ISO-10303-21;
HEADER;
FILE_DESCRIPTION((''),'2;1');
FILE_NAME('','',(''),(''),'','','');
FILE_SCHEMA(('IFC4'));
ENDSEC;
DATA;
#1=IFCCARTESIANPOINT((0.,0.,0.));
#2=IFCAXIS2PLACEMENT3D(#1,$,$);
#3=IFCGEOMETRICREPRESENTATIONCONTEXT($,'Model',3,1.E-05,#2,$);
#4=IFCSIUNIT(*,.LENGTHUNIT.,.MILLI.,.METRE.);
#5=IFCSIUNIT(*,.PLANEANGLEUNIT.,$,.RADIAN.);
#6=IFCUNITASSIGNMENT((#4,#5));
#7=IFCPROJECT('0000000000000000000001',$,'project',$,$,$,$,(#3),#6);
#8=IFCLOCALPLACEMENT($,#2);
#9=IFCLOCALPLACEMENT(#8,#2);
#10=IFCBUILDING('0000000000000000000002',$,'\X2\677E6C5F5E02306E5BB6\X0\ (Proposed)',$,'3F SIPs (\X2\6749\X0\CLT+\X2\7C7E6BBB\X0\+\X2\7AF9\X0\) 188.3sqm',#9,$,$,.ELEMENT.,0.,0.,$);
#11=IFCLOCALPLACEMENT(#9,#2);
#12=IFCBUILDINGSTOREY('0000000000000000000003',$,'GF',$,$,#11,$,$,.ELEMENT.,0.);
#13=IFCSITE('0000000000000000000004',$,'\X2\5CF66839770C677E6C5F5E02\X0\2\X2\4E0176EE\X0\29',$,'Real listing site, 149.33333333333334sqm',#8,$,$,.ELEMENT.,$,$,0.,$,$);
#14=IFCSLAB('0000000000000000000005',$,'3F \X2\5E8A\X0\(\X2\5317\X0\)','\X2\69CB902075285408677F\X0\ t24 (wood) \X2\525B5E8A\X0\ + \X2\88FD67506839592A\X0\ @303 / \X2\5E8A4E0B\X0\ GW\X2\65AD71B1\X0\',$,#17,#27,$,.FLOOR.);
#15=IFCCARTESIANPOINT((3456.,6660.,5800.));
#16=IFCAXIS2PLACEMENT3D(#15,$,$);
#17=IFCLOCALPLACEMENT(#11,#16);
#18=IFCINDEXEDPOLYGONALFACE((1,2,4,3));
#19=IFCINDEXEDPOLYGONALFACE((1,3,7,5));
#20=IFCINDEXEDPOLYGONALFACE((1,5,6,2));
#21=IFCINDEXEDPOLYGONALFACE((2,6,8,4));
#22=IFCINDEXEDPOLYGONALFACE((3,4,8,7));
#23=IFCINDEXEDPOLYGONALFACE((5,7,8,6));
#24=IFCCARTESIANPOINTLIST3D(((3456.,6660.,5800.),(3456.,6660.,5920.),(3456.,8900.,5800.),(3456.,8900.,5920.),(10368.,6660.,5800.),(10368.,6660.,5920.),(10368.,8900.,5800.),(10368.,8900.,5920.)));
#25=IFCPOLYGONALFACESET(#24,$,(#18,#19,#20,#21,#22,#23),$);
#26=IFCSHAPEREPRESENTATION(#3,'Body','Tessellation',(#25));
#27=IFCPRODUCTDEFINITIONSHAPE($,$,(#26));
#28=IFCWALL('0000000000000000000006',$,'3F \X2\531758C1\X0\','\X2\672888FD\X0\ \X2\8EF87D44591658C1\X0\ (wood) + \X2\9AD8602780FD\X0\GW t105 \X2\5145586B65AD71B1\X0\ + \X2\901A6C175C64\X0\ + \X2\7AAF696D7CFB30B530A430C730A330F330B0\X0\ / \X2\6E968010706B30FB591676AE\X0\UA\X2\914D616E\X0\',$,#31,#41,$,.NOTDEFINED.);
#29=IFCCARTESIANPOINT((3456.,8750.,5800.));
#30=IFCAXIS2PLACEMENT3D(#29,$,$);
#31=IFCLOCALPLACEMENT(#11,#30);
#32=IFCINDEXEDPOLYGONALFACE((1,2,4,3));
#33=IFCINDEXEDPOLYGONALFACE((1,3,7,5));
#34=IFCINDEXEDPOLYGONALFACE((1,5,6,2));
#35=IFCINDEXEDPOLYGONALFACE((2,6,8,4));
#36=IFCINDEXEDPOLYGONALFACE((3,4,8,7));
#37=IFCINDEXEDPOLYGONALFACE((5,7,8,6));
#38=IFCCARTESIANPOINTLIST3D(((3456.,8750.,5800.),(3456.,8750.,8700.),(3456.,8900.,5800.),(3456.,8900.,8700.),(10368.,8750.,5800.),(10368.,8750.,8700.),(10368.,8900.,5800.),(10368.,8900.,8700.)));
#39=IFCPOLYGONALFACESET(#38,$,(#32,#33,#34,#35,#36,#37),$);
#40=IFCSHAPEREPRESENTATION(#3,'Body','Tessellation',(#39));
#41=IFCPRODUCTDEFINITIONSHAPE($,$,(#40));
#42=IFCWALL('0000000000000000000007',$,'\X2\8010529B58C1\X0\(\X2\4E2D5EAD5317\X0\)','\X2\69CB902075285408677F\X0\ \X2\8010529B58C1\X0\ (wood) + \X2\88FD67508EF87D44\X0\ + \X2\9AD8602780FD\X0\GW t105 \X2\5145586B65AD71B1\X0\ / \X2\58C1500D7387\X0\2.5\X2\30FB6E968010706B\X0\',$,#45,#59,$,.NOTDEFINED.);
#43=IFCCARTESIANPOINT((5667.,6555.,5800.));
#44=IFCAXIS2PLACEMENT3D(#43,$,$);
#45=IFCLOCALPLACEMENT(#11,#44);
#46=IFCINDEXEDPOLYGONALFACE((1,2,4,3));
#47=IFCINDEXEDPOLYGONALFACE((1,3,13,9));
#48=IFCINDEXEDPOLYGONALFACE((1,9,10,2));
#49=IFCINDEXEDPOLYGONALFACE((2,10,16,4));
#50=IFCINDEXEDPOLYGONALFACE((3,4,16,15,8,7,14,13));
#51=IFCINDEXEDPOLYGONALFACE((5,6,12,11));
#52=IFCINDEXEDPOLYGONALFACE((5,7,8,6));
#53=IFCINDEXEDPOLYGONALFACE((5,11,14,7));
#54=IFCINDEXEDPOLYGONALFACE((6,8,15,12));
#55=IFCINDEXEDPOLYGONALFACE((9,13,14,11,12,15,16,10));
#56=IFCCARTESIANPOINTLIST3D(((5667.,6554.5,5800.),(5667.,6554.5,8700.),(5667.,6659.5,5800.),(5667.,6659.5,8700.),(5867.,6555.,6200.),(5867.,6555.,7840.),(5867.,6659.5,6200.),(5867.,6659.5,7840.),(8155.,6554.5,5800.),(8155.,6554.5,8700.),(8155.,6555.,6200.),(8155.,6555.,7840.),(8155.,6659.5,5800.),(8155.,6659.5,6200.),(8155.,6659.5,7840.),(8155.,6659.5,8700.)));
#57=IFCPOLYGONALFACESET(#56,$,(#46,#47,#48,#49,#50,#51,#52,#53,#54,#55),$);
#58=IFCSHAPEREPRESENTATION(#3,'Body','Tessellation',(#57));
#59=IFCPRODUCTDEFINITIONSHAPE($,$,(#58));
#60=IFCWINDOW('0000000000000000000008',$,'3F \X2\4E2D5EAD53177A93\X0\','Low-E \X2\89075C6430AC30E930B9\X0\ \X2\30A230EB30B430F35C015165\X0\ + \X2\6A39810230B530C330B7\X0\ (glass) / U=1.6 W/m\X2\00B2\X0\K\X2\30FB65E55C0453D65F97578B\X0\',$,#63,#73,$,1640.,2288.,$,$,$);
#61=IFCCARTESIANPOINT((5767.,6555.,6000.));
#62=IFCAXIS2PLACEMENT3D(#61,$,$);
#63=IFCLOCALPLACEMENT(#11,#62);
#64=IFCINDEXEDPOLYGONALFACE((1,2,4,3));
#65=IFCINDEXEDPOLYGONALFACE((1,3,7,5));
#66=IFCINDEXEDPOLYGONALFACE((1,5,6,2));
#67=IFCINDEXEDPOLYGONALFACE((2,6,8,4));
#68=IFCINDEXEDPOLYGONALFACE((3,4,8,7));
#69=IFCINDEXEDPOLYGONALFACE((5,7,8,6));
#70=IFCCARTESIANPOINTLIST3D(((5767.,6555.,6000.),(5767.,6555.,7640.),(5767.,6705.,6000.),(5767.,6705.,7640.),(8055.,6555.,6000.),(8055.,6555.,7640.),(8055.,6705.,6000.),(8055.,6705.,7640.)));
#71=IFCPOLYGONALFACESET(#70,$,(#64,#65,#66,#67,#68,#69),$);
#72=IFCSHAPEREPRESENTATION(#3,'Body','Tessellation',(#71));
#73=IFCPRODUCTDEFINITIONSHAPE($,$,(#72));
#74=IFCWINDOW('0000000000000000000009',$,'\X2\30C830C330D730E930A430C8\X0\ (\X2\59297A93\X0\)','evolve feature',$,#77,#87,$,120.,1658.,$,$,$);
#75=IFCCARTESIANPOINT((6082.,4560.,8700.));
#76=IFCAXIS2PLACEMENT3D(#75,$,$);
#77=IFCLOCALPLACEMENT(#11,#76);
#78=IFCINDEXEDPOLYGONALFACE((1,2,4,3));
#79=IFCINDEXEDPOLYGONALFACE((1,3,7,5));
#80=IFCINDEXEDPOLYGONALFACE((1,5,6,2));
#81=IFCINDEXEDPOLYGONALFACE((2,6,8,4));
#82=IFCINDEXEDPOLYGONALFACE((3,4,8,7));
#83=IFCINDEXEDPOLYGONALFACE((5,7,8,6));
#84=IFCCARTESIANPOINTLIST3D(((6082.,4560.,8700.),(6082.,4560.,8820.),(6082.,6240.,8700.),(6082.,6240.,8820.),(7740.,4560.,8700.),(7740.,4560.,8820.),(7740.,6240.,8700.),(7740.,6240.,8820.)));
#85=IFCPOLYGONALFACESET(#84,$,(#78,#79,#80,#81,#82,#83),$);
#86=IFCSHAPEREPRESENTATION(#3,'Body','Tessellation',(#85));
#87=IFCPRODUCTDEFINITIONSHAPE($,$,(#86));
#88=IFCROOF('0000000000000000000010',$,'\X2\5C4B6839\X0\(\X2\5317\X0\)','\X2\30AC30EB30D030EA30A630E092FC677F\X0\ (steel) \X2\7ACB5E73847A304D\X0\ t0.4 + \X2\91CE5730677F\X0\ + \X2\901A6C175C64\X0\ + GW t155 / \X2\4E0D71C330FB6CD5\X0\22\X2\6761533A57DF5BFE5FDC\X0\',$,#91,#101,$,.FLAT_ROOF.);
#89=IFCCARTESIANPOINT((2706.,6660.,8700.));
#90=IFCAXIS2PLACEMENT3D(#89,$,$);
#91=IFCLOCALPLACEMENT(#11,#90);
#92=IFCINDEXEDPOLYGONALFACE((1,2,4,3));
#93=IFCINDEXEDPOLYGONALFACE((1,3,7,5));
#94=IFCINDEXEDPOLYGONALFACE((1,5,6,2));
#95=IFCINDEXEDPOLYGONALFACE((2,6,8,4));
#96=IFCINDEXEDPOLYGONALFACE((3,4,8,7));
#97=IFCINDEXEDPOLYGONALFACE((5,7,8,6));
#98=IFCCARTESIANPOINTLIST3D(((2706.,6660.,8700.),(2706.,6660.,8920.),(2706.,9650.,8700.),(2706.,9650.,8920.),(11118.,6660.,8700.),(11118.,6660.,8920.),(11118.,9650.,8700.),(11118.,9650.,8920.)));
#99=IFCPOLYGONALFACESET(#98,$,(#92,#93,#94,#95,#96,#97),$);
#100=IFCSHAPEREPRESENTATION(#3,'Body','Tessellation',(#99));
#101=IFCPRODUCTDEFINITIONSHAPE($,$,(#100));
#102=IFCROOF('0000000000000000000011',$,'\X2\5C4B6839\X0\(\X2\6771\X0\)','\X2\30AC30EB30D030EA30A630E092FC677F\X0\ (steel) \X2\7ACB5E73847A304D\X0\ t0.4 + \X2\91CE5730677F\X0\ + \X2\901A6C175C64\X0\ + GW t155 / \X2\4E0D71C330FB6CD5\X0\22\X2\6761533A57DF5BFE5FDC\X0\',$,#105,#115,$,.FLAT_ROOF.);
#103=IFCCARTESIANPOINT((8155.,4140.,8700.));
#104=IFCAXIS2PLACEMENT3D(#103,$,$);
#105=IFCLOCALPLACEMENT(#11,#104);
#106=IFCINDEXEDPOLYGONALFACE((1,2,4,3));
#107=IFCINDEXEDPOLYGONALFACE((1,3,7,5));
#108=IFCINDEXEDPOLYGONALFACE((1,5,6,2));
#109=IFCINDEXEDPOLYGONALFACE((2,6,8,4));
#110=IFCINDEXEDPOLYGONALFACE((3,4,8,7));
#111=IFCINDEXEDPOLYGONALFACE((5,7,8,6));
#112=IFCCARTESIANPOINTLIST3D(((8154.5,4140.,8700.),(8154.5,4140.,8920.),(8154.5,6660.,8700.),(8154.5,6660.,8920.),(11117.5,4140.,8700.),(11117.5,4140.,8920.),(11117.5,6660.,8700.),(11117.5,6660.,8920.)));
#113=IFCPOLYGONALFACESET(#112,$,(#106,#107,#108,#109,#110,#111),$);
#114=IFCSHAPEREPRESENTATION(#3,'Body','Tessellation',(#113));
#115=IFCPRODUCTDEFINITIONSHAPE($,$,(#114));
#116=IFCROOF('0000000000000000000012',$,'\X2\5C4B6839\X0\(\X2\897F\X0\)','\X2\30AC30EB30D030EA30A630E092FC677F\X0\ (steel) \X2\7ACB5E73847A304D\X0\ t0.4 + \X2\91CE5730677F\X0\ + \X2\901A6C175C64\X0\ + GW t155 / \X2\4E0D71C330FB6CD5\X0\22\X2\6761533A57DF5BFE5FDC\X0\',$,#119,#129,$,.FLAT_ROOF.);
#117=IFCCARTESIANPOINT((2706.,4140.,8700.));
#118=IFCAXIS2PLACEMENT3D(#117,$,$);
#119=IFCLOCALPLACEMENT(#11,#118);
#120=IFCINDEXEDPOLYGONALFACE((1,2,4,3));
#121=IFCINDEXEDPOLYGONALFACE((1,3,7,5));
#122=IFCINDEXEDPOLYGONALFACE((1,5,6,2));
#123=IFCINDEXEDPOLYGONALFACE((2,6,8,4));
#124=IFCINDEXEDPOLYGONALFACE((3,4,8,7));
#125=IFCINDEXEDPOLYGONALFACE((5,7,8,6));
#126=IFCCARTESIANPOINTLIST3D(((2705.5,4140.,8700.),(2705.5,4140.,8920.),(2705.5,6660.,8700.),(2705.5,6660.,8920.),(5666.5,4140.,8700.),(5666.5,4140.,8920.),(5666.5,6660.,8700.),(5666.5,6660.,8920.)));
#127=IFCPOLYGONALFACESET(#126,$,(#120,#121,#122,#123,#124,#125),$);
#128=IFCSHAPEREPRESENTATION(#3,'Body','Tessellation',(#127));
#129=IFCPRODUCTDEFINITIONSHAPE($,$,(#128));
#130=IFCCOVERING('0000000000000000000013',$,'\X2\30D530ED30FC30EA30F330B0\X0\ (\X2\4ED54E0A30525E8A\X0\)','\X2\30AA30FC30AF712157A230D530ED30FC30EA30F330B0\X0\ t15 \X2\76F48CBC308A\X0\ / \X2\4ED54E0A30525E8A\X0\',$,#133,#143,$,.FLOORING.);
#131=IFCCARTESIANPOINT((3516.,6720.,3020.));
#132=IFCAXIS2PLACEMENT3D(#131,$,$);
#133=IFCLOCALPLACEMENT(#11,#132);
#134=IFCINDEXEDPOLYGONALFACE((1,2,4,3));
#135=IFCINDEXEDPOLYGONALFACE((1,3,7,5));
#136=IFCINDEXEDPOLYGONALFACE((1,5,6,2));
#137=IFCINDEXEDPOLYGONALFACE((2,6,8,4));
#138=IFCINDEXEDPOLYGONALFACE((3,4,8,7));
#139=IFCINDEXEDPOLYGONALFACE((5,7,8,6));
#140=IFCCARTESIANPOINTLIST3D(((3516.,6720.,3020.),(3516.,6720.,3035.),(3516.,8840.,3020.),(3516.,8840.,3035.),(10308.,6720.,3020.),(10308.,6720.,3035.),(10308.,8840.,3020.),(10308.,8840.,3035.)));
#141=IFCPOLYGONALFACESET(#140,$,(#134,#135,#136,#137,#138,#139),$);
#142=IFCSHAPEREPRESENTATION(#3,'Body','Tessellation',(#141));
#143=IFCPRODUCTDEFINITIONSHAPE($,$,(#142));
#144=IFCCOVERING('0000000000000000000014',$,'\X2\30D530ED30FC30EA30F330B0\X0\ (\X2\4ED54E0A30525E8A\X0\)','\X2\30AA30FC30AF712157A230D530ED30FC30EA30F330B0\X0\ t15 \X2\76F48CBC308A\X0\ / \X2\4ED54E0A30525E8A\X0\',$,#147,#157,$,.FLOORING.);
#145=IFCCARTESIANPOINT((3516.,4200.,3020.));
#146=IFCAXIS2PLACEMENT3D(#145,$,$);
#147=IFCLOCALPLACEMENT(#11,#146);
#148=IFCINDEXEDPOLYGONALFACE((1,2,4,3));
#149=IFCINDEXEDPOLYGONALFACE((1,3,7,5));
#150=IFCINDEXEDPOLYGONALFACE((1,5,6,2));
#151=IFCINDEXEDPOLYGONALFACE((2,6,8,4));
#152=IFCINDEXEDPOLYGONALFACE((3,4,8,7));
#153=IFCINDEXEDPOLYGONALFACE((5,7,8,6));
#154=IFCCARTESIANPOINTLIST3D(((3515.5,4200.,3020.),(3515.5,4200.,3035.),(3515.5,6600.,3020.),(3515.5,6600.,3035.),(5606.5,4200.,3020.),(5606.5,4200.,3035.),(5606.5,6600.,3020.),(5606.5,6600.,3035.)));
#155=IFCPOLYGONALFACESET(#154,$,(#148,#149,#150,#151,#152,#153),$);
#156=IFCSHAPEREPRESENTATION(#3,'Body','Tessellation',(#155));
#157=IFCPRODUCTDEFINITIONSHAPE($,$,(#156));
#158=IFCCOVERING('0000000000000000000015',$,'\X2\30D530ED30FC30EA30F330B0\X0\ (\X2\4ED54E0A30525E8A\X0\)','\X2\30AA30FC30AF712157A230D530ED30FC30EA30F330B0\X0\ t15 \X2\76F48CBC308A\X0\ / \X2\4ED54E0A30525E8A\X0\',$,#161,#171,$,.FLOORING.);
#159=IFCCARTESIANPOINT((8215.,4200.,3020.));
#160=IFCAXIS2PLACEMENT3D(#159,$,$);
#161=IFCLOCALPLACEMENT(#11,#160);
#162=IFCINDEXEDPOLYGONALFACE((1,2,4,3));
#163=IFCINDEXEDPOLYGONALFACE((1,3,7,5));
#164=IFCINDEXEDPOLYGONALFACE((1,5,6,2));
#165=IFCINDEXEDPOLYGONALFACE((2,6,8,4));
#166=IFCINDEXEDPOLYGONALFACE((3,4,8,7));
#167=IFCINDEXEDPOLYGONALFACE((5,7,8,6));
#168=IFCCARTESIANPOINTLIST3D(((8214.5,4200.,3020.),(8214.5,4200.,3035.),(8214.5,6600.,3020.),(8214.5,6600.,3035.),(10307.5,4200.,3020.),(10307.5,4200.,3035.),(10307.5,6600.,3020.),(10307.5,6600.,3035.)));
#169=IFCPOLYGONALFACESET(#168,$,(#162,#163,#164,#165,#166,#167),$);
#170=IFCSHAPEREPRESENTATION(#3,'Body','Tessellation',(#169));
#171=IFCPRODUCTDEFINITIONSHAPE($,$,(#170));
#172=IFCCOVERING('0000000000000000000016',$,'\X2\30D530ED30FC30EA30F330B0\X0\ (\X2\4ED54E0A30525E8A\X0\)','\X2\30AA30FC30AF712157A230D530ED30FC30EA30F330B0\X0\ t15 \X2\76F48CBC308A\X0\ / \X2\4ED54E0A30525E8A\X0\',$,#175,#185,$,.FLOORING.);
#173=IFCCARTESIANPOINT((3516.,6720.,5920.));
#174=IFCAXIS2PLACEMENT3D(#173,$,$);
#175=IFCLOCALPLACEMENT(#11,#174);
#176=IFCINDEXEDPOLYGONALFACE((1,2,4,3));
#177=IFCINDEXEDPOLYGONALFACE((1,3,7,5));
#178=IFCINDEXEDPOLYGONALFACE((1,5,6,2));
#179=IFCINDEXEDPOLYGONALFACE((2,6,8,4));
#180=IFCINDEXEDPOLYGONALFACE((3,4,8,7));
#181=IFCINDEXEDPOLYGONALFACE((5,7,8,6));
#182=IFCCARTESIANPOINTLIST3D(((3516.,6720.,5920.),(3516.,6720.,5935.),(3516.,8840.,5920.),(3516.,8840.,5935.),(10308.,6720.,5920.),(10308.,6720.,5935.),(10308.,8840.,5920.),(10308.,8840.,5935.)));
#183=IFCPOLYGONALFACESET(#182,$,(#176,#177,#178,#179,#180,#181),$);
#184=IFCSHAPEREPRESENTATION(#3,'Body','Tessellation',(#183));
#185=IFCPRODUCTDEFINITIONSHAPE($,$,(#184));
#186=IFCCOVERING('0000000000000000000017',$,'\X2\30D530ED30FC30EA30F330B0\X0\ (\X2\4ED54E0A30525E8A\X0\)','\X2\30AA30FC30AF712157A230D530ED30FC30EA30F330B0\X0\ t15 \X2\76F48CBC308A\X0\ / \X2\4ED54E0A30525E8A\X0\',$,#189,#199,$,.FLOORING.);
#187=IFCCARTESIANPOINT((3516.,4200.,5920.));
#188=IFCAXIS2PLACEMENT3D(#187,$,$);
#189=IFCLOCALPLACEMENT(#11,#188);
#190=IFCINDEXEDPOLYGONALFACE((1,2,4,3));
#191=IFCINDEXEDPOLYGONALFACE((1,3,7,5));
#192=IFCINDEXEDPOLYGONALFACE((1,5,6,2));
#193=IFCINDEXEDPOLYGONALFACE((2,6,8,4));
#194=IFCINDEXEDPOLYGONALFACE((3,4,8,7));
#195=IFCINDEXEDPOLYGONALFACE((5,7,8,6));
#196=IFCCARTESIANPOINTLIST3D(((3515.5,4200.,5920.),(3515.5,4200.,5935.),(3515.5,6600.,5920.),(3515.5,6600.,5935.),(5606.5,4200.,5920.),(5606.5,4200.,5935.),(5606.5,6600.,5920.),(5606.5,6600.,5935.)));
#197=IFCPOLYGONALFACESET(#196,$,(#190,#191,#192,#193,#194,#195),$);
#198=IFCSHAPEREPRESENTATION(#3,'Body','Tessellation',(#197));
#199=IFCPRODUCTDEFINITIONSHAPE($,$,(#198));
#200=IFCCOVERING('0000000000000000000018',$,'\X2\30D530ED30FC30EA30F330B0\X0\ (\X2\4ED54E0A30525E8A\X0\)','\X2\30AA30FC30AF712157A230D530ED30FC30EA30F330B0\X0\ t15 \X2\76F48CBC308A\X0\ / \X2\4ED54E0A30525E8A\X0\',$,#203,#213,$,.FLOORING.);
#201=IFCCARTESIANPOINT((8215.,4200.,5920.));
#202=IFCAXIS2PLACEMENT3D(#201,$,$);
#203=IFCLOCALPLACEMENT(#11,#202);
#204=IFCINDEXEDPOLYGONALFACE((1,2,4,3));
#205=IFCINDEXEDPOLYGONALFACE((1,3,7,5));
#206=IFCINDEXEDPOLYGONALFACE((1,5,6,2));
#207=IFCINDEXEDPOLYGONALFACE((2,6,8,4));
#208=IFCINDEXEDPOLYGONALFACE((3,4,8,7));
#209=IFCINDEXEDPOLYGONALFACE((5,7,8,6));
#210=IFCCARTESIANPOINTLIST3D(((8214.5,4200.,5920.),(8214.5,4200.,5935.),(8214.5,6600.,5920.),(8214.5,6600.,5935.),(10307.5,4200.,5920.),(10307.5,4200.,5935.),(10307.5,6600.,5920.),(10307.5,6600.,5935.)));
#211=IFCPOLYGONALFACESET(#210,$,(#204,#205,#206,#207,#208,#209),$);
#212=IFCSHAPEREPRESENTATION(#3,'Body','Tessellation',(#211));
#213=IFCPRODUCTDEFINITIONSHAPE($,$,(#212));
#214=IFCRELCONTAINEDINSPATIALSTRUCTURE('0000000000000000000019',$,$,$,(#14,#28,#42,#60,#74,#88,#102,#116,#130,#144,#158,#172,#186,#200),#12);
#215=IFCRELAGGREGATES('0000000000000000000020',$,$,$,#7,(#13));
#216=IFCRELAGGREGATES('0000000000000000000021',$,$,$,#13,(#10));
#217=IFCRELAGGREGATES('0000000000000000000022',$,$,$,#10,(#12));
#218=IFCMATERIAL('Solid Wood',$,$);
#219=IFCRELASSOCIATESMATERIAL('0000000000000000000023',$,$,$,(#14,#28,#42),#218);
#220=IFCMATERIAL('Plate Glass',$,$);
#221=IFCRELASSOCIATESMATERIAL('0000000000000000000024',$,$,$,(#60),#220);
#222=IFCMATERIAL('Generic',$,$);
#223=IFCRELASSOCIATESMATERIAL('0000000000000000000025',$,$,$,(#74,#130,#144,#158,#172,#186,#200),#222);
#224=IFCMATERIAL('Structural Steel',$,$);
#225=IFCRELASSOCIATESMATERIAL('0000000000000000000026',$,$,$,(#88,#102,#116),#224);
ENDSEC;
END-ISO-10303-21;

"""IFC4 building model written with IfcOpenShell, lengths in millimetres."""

from ifc_helpers import new_model, si_unit, frame, frame_2d, origin, place, context, project, spatial, rectangle, extrude, material, element, fill, save


model = new_model("IFC4")

# Units and contexts
model_context = context("Model", 3, precision=1e-05, world=origin())
ifc_project = project(units=[si_unit("LENGTHUNIT", "METRE", prefix="MILLI"), si_unit("PLANEANGLEUNIT", "RADIAN")], contexts=[model_context])

# Site, building, storey
site_placement = place(None, origin())
site = spatial("IfcSite", under=ifc_project, at=site_placement, Name="島根県松江市2丁目29", ObjectType="Real listing site, 149.33333333333334sqm", CompositionType="ELEMENT", RefElevation=0.0)
building_placement = place(site_placement, origin())
building = spatial("IfcBuilding", under=site, at=building_placement, Name="松江市の家 (Proposed)", ObjectType="3F SIPs (杉CLT+籾殻+竹) 188.3sqm", CompositionType="ELEMENT", ElevationOfRefHeight=0.0, ElevationOfTerrain=0.0)
storey_placement = place(building_placement, origin())
storey = spatial("IfcBuildingStorey", under=building, at=storey_placement, Name="GF", CompositionType="ELEMENT", Elevation=0.0)

# Slab
ifc_material_1 = material(Name="Solid Wood")
slab_placement = place(storey_placement, frame((3456.0, 6660.0, 5800.0)))
element("IfcSlab", 1, at=slab_placement, inside=storey, material=ifc_material_1, Name="3F 床(北)", Description="構造用合板 t24 (wood) 剛床 + 製材根太 @303 / 床下 GW断熱", PredefinedType="FLOOR", context=model_context, shape_type="SweptSolid", body=[
    extrude(rectangle(XDim=6912.0, YDim=2240.0, at=frame_2d((3456.0, 1120.0))), frame((3456.0, 6660.0, 5800.0)), (0.0, 0.0, 1.0), 120.0),
])

# Wall
wall_1_placement = place(storey_placement, frame((3456.0, 8750.0, 5800.0)))
element("IfcWall", 2, at=wall_1_placement, inside=storey, material=ifc_material_1, Name="3F 北壁", Description="木製 軸組外壁 (wood) + 高性能GW t105 充填断熱 + 通気層 + 窯業系サイディング / 準耐火・外皮UA配慮", PredefinedType="NOTDEFINED", context=model_context, shape_type="SweptSolid", body=[
    extrude(rectangle(XDim=6912.0, YDim=150.0, at=frame_2d((3456.0, 75.0))), frame((3456.0, 8750.0, 5800.0)), (0.0, 0.0, 1.0), 2900.0),
])

# Wall, opening, window
wall_2_placement = place(storey_placement, frame((5667.0, 6555.0, 5800.0)))
wall_2 = element("IfcWall", 3, at=wall_2_placement, inside=storey, material=ifc_material_1, Name="耐力壁(中庭北)", Description="構造用合板 耐力壁 (wood) + 製材軸組 + 高性能GW t105 充填断熱 / 壁倍率2.5・準耐火", PredefinedType="NOTDEFINED", context=model_context, shape_type="SweptSolid", body=[
    extrude(rectangle(XDim=2488.0, YDim=105.0, at=frame_2d((1244.0, 52.0))), frame((5667.0, 6555.0, 5800.0)), (0.0, 0.0, 1.0), 2900.0),
])
opening_placement = place(storey_placement, frame((5767.0, 6555.0, 6000.0)))
opening = element("IfcOpeningElement", 4, at=opening_placement, cuts=wall_2, PredefinedType="NOTDEFINED", context=model_context, shape_type="SweptSolid", body=[
    extrude(rectangle(XDim=2288.0, YDim=150.0, at=frame_2d((1144.0, 75.0))), frame((5767.0, 6555.0, 6000.0)), (0.0, 0.0, 1.0), 1640.0),
])
ifc_material_2 = material(Name="Plate Glass")
window_1_placement = place(storey_placement, frame((5767.0, 6555.0, 6000.0)))
window_1 = element("IfcWindow", 5, at=window_1_placement, inside=storey, material=ifc_material_2, Name="3F 中庭北窓", Description="Low-E 複層ガラス アルゴン封入 + 樹脂サッシ (glass) / U=1.6 W/m²K・日射取得型", OverallHeight=1640.0, OverallWidth=2288.0, context=model_context, shape_type="SweptSolid", body=[
    extrude(rectangle(XDim=2288.0, YDim=150.0, at=frame_2d((1144.0, 75.0))), frame((5767.0, 6555.0, 6000.0)), (0.0, 0.0, 1.0), 1640.0),
])
fill(opening, window_1)

# Window
ifc_material_3 = material(Name="Generic")
window_2_placement = place(storey_placement, frame((6082.0, 4560.0, 8700.0)))
element("IfcWindow", 6, at=window_2_placement, inside=storey, material=ifc_material_3, Name="トップライト (天窓)", Description="evolve feature", OverallHeight=120.0, OverallWidth=1658.0, context=model_context, shape_type="SweptSolid", body=[
    extrude(rectangle(XDim=1658.0, YDim=1680.0, at=frame_2d((829.0, 840.0))), frame((6082.0, 4560.0, 8700.0)), (0.0, 0.0, 1.0), 120.0),
])

# Roofs
ifc_material_4 = material(Name="Structural Steel")
roof_1_placement = place(storey_placement, frame((2706.0, 6660.0, 8700.0)))
element("IfcRoof", 7, at=roof_1_placement, inside=storey, material=ifc_material_4, Name="屋根(北)", Description="ガルバリウム鋼板 (steel) 立平葺き t0.4 + 野地板 + 通気層 + GW t155 / 不燃・法22条区域対応", PredefinedType="FLAT_ROOF", context=model_context, shape_type="SweptSolid", body=[
    extrude(rectangle(XDim=8412.0, YDim=2990.0, at=frame_2d((4206.0, 1495.0))), frame((2706.0, 6660.0, 8700.0)), (0.0, 0.0, 1.0), 220.0),
])
roof_2_placement = place(storey_placement, frame((8155.0, 4140.0, 8700.0)))
element("IfcRoof", 8, at=roof_2_placement, inside=storey, material=ifc_material_4, Name="屋根(東)", Description="ガルバリウム鋼板 (steel) 立平葺き t0.4 + 野地板 + 通気層 + GW t155 / 不燃・法22条区域対応", PredefinedType="FLAT_ROOF", context=model_context, shape_type="SweptSolid", body=[
    extrude(rectangle(XDim=2963.0, YDim=2520.0, at=frame_2d((1481.0, 1260.0))), frame((8155.0, 4140.0, 8700.0)), (0.0, 0.0, 1.0), 220.0),
])
roof_3_placement = place(storey_placement, frame((2706.0, 4140.0, 8700.0)))
element("IfcRoof", 9, at=roof_3_placement, inside=storey, material=ifc_material_4, Name="屋根(西)", Description="ガルバリウム鋼板 (steel) 立平葺き t0.4 + 野地板 + 通気層 + GW t155 / 不燃・法22条区域対応", PredefinedType="FLAT_ROOF", context=model_context, shape_type="SweptSolid", body=[
    extrude(rectangle(XDim=2961.0, YDim=2520.0, at=frame_2d((1480.0, 1260.0))), frame((2706.0, 4140.0, 8700.0)), (0.0, 0.0, 1.0), 220.0),
])

# Coverings
covering_1_placement = place(storey_placement, frame((3516.0, 6720.0, 3020.0)))
element("IfcCovering", 10, at=covering_1_placement, inside=storey, material=ifc_material_3, Name="フローリング (仕上げ床)", Description="オーク無垢フローリング t15 直貼り / 仕上げ床", PredefinedType="FLOORING", context=model_context, shape_type="SweptSolid", body=[
    extrude(rectangle(XDim=6792.0, YDim=2120.0, at=frame_2d((3396.0, 1060.0))), frame((3516.0, 6720.0, 3020.0)), (0.0, 0.0, 1.0), 15.0),
])
covering_2_placement = place(storey_placement, frame((3516.0, 4200.0, 3020.0)))
element("IfcCovering", 11, at=covering_2_placement, inside=storey, material=ifc_material_3, Name="フローリング (仕上げ床)", Description="オーク無垢フローリング t15 直貼り / 仕上げ床", PredefinedType="FLOORING", context=model_context, shape_type="SweptSolid", body=[
    extrude(rectangle(XDim=2091.0, YDim=2400.0, at=frame_2d((1045.0, 1200.0))), frame((3516.0, 4200.0, 3020.0)), (0.0, 0.0, 1.0), 15.0),
])
covering_3_placement = place(storey_placement, frame((8215.0, 4200.0, 3020.0)))
element("IfcCovering", 12, at=covering_3_placement, inside=storey, material=ifc_material_3, Name="フローリング (仕上げ床)", Description="オーク無垢フローリング t15 直貼り / 仕上げ床", PredefinedType="FLOORING", context=model_context, shape_type="SweptSolid", body=[
    extrude(rectangle(XDim=2093.0, YDim=2400.0, at=frame_2d((1046.0, 1200.0))), frame((8215.0, 4200.0, 3020.0)), (0.0, 0.0, 1.0), 15.0),
])
covering_4_placement = place(storey_placement, frame((3516.0, 6720.0, 5920.0)))
element("IfcCovering", 13, at=covering_4_placement, inside=storey, material=ifc_material_3, Name="フローリング (仕上げ床)", Description="オーク無垢フローリング t15 直貼り / 仕上げ床", PredefinedType="FLOORING", context=model_context, shape_type="SweptSolid", body=[
    extrude(rectangle(XDim=6792.0, YDim=2120.0, at=frame_2d((3396.0, 1060.0))), frame((3516.0, 6720.0, 5920.0)), (0.0, 0.0, 1.0), 15.0),
])
covering_5_placement = place(storey_placement, frame((3516.0, 4200.0, 5920.0)))
element("IfcCovering", 14, at=covering_5_placement, inside=storey, material=ifc_material_3, Name="フローリング (仕上げ床)", Description="オーク無垢フローリング t15 直貼り / 仕上げ床", PredefinedType="FLOORING", context=model_context, shape_type="SweptSolid", body=[
    extrude(rectangle(XDim=2091.0, YDim=2400.0, at=frame_2d((1045.0, 1200.0))), frame((3516.0, 4200.0, 5920.0)), (0.0, 0.0, 1.0), 15.0),
])
covering_6_placement = place(storey_placement, frame((8215.0, 4200.0, 5920.0)))
element("IfcCovering", 15, at=covering_6_placement, inside=storey, material=ifc_material_3, Name="フローリング (仕上げ床)", Description="オーク無垢フローリング t15 直貼り / 仕上げ床", PredefinedType="FLOORING", context=model_context, shape_type="SweptSolid", body=[
    extrude(rectangle(XDim=2093.0, YDim=2400.0, at=frame_2d((1046.0, 1200.0))), frame((8215.0, 4200.0, 5920.0)), (0.0, 0.0, 1.0), 15.0),
])

save(model, "model.ifc")
